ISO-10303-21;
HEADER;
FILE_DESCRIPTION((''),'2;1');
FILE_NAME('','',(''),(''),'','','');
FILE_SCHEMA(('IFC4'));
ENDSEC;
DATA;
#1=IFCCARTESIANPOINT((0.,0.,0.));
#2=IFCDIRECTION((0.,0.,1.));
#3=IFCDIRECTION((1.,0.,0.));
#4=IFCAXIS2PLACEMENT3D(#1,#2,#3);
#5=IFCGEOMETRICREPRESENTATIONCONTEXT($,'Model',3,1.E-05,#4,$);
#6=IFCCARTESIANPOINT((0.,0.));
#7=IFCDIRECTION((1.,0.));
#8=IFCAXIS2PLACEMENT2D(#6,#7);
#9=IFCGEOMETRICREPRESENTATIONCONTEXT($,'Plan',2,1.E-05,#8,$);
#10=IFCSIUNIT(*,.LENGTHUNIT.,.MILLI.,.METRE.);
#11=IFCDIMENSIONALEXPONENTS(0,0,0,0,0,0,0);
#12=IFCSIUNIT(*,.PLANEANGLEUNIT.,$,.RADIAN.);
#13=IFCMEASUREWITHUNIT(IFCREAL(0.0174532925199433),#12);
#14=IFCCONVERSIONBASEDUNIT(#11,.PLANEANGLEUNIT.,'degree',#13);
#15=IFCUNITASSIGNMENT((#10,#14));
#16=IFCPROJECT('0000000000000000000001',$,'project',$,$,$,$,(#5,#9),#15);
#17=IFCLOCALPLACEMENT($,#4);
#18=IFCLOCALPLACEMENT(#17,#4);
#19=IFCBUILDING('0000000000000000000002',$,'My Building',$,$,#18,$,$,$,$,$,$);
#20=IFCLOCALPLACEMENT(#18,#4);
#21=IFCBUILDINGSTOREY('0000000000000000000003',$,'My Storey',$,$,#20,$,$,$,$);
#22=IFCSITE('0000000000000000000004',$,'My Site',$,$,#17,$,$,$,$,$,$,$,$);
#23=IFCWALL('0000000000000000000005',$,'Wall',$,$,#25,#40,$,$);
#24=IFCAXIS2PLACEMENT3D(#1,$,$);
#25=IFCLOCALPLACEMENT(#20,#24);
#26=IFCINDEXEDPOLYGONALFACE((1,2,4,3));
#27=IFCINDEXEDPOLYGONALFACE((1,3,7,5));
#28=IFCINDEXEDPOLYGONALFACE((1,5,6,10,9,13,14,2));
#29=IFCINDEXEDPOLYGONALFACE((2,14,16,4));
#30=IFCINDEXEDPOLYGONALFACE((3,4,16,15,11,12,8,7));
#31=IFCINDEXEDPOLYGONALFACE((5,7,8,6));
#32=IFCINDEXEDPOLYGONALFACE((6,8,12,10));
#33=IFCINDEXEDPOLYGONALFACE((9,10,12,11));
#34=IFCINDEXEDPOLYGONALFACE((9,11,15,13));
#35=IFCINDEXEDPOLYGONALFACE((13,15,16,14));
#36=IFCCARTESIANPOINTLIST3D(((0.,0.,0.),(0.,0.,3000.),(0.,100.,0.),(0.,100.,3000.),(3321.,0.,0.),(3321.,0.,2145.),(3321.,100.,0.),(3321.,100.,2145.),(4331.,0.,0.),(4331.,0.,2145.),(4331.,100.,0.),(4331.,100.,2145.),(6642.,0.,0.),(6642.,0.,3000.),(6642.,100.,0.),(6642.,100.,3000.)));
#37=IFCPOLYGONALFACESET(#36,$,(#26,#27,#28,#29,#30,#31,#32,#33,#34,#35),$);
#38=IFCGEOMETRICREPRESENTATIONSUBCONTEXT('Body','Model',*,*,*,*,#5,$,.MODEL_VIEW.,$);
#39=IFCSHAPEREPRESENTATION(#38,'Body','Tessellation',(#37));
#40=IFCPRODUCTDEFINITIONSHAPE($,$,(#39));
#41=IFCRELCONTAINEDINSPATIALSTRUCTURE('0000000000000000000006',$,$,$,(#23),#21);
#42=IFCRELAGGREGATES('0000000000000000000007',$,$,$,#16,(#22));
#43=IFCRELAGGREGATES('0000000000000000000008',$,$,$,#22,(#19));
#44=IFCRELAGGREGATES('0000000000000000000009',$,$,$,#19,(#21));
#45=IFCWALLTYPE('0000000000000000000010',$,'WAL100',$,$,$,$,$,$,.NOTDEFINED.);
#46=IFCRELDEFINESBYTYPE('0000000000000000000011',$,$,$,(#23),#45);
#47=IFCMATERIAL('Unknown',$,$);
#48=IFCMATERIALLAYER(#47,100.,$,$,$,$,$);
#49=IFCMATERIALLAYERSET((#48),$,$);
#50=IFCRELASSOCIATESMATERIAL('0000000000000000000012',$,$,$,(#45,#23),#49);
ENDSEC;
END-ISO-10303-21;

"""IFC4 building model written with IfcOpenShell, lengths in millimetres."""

from ifc_helpers import new_model, entity, si_unit, converted_unit, frame, origin_with_axes, origin_2d_with_axis, place, context, subcontext, project, spatial, line, indexed_curve, outline, extrude, source, transform, mapped, material, layer, layer_set, layer_usage, type_object, element, save


model = new_model("IFC4")

# Units and contexts
model_context = context("Model", 3, precision=1e-05, world=origin_with_axes())
plan_context = context("Plan", 2, precision=1e-05, world=origin_2d_with_axis())
body_context = subcontext(model_context, "Body", "Model", "MODEL_VIEW")
ifc_project = project(units=[si_unit("LENGTHUNIT", "METRE", prefix="MILLI"), converted_unit("PLANEANGLEUNIT", "degree", entity("IfcReal", 0.0174532925199433), si_unit("PLANEANGLEUNIT", "RADIAN"), dimensions=[0, 0, 0, 0, 0, 0, 0])], contexts=[model_context, plan_context])

# Site, building, storey
site_placement = place(None, origin_with_axes())
site = spatial("IfcSite", under=ifc_project, at=site_placement, Name="My Site")
building_placement = place(site_placement, origin_with_axes())
building = spatial("IfcBuilding", under=site, at=building_placement, Name="My Building")
storey_placement = place(building_placement, origin_with_axes())
storey = spatial("IfcBuildingStorey", under=building, at=storey_placement, Name="My Storey")

# Wall, opening
ifc_material = material(Name="Unknown")
ifc_layer = layer(ifc_material, 100.0)
ifc_layer_set = layer_set([ifc_layer])
ifc_layer_usage_1 = layer_usage(ifc_layer_set, "AXIS2", "POSITIVE", 0.0)
wall_type = type_object("IfcWallType", Name="WAL100", PredefinedType="NOTDEFINED", material=ifc_layer_set)
wall_1_placement = place(storey_placement, origin_with_axes())
wall_1 = element("IfcWall", 1, at=wall_1_placement, inside=storey, type_object=wall_type, material=ifc_layer_usage_1, Name="Wall", context=body_context, shape_type="SweptSolid", body=[
    extrude(outline(indexed_curve([(0.0, 0.0), (0.0, 100.0), (6642.0, 100.0), (6642.0, 0.0), (0.0, 0.0)], self_intersect=False)), origin_with_axes(), (0.0, 0.0, 1.0), 3000.0),
])
shared_shape = source(origin_with_axes(), body_context, "Body", "SweptSolid", [
    extrude(outline(indexed_curve([(0.0, 0.0), (1010.0, 0.0), (1010.0, 2145.0), (0.0, 2145.0)], segments=[line(1, 2, 3, 4, 1)])), frame((0.0, -100.0, 0.0), z_axis=(0.0, -1.0, 0.0), x_axis=(1.0, 0.0, 0.0)), (0.0, 0.0, -1.0), 300.0),
])
opening_placement = place(wall_1_placement, frame((3321.0, 0.0, 0.0), z_axis=(0.0, 0.0, 1.0), x_axis=(1.0, 0.0, 0.0)))
element("IfcOpeningElement", 2, at=opening_placement, cuts=wall_1, PredefinedType="OPENING", context=body_context, shape_type="MappedRepresentation", body=[
    mapped(shared_shape, transform((0.0, 0.0, 0.0), x_axis=(1.0, 0.0, 0.0), y_axis=(0.0, 1.0, 0.0), z_axis=(0.0, 0.0, 1.0), scale=1.0)),
])

save(model, "model.ifc")
